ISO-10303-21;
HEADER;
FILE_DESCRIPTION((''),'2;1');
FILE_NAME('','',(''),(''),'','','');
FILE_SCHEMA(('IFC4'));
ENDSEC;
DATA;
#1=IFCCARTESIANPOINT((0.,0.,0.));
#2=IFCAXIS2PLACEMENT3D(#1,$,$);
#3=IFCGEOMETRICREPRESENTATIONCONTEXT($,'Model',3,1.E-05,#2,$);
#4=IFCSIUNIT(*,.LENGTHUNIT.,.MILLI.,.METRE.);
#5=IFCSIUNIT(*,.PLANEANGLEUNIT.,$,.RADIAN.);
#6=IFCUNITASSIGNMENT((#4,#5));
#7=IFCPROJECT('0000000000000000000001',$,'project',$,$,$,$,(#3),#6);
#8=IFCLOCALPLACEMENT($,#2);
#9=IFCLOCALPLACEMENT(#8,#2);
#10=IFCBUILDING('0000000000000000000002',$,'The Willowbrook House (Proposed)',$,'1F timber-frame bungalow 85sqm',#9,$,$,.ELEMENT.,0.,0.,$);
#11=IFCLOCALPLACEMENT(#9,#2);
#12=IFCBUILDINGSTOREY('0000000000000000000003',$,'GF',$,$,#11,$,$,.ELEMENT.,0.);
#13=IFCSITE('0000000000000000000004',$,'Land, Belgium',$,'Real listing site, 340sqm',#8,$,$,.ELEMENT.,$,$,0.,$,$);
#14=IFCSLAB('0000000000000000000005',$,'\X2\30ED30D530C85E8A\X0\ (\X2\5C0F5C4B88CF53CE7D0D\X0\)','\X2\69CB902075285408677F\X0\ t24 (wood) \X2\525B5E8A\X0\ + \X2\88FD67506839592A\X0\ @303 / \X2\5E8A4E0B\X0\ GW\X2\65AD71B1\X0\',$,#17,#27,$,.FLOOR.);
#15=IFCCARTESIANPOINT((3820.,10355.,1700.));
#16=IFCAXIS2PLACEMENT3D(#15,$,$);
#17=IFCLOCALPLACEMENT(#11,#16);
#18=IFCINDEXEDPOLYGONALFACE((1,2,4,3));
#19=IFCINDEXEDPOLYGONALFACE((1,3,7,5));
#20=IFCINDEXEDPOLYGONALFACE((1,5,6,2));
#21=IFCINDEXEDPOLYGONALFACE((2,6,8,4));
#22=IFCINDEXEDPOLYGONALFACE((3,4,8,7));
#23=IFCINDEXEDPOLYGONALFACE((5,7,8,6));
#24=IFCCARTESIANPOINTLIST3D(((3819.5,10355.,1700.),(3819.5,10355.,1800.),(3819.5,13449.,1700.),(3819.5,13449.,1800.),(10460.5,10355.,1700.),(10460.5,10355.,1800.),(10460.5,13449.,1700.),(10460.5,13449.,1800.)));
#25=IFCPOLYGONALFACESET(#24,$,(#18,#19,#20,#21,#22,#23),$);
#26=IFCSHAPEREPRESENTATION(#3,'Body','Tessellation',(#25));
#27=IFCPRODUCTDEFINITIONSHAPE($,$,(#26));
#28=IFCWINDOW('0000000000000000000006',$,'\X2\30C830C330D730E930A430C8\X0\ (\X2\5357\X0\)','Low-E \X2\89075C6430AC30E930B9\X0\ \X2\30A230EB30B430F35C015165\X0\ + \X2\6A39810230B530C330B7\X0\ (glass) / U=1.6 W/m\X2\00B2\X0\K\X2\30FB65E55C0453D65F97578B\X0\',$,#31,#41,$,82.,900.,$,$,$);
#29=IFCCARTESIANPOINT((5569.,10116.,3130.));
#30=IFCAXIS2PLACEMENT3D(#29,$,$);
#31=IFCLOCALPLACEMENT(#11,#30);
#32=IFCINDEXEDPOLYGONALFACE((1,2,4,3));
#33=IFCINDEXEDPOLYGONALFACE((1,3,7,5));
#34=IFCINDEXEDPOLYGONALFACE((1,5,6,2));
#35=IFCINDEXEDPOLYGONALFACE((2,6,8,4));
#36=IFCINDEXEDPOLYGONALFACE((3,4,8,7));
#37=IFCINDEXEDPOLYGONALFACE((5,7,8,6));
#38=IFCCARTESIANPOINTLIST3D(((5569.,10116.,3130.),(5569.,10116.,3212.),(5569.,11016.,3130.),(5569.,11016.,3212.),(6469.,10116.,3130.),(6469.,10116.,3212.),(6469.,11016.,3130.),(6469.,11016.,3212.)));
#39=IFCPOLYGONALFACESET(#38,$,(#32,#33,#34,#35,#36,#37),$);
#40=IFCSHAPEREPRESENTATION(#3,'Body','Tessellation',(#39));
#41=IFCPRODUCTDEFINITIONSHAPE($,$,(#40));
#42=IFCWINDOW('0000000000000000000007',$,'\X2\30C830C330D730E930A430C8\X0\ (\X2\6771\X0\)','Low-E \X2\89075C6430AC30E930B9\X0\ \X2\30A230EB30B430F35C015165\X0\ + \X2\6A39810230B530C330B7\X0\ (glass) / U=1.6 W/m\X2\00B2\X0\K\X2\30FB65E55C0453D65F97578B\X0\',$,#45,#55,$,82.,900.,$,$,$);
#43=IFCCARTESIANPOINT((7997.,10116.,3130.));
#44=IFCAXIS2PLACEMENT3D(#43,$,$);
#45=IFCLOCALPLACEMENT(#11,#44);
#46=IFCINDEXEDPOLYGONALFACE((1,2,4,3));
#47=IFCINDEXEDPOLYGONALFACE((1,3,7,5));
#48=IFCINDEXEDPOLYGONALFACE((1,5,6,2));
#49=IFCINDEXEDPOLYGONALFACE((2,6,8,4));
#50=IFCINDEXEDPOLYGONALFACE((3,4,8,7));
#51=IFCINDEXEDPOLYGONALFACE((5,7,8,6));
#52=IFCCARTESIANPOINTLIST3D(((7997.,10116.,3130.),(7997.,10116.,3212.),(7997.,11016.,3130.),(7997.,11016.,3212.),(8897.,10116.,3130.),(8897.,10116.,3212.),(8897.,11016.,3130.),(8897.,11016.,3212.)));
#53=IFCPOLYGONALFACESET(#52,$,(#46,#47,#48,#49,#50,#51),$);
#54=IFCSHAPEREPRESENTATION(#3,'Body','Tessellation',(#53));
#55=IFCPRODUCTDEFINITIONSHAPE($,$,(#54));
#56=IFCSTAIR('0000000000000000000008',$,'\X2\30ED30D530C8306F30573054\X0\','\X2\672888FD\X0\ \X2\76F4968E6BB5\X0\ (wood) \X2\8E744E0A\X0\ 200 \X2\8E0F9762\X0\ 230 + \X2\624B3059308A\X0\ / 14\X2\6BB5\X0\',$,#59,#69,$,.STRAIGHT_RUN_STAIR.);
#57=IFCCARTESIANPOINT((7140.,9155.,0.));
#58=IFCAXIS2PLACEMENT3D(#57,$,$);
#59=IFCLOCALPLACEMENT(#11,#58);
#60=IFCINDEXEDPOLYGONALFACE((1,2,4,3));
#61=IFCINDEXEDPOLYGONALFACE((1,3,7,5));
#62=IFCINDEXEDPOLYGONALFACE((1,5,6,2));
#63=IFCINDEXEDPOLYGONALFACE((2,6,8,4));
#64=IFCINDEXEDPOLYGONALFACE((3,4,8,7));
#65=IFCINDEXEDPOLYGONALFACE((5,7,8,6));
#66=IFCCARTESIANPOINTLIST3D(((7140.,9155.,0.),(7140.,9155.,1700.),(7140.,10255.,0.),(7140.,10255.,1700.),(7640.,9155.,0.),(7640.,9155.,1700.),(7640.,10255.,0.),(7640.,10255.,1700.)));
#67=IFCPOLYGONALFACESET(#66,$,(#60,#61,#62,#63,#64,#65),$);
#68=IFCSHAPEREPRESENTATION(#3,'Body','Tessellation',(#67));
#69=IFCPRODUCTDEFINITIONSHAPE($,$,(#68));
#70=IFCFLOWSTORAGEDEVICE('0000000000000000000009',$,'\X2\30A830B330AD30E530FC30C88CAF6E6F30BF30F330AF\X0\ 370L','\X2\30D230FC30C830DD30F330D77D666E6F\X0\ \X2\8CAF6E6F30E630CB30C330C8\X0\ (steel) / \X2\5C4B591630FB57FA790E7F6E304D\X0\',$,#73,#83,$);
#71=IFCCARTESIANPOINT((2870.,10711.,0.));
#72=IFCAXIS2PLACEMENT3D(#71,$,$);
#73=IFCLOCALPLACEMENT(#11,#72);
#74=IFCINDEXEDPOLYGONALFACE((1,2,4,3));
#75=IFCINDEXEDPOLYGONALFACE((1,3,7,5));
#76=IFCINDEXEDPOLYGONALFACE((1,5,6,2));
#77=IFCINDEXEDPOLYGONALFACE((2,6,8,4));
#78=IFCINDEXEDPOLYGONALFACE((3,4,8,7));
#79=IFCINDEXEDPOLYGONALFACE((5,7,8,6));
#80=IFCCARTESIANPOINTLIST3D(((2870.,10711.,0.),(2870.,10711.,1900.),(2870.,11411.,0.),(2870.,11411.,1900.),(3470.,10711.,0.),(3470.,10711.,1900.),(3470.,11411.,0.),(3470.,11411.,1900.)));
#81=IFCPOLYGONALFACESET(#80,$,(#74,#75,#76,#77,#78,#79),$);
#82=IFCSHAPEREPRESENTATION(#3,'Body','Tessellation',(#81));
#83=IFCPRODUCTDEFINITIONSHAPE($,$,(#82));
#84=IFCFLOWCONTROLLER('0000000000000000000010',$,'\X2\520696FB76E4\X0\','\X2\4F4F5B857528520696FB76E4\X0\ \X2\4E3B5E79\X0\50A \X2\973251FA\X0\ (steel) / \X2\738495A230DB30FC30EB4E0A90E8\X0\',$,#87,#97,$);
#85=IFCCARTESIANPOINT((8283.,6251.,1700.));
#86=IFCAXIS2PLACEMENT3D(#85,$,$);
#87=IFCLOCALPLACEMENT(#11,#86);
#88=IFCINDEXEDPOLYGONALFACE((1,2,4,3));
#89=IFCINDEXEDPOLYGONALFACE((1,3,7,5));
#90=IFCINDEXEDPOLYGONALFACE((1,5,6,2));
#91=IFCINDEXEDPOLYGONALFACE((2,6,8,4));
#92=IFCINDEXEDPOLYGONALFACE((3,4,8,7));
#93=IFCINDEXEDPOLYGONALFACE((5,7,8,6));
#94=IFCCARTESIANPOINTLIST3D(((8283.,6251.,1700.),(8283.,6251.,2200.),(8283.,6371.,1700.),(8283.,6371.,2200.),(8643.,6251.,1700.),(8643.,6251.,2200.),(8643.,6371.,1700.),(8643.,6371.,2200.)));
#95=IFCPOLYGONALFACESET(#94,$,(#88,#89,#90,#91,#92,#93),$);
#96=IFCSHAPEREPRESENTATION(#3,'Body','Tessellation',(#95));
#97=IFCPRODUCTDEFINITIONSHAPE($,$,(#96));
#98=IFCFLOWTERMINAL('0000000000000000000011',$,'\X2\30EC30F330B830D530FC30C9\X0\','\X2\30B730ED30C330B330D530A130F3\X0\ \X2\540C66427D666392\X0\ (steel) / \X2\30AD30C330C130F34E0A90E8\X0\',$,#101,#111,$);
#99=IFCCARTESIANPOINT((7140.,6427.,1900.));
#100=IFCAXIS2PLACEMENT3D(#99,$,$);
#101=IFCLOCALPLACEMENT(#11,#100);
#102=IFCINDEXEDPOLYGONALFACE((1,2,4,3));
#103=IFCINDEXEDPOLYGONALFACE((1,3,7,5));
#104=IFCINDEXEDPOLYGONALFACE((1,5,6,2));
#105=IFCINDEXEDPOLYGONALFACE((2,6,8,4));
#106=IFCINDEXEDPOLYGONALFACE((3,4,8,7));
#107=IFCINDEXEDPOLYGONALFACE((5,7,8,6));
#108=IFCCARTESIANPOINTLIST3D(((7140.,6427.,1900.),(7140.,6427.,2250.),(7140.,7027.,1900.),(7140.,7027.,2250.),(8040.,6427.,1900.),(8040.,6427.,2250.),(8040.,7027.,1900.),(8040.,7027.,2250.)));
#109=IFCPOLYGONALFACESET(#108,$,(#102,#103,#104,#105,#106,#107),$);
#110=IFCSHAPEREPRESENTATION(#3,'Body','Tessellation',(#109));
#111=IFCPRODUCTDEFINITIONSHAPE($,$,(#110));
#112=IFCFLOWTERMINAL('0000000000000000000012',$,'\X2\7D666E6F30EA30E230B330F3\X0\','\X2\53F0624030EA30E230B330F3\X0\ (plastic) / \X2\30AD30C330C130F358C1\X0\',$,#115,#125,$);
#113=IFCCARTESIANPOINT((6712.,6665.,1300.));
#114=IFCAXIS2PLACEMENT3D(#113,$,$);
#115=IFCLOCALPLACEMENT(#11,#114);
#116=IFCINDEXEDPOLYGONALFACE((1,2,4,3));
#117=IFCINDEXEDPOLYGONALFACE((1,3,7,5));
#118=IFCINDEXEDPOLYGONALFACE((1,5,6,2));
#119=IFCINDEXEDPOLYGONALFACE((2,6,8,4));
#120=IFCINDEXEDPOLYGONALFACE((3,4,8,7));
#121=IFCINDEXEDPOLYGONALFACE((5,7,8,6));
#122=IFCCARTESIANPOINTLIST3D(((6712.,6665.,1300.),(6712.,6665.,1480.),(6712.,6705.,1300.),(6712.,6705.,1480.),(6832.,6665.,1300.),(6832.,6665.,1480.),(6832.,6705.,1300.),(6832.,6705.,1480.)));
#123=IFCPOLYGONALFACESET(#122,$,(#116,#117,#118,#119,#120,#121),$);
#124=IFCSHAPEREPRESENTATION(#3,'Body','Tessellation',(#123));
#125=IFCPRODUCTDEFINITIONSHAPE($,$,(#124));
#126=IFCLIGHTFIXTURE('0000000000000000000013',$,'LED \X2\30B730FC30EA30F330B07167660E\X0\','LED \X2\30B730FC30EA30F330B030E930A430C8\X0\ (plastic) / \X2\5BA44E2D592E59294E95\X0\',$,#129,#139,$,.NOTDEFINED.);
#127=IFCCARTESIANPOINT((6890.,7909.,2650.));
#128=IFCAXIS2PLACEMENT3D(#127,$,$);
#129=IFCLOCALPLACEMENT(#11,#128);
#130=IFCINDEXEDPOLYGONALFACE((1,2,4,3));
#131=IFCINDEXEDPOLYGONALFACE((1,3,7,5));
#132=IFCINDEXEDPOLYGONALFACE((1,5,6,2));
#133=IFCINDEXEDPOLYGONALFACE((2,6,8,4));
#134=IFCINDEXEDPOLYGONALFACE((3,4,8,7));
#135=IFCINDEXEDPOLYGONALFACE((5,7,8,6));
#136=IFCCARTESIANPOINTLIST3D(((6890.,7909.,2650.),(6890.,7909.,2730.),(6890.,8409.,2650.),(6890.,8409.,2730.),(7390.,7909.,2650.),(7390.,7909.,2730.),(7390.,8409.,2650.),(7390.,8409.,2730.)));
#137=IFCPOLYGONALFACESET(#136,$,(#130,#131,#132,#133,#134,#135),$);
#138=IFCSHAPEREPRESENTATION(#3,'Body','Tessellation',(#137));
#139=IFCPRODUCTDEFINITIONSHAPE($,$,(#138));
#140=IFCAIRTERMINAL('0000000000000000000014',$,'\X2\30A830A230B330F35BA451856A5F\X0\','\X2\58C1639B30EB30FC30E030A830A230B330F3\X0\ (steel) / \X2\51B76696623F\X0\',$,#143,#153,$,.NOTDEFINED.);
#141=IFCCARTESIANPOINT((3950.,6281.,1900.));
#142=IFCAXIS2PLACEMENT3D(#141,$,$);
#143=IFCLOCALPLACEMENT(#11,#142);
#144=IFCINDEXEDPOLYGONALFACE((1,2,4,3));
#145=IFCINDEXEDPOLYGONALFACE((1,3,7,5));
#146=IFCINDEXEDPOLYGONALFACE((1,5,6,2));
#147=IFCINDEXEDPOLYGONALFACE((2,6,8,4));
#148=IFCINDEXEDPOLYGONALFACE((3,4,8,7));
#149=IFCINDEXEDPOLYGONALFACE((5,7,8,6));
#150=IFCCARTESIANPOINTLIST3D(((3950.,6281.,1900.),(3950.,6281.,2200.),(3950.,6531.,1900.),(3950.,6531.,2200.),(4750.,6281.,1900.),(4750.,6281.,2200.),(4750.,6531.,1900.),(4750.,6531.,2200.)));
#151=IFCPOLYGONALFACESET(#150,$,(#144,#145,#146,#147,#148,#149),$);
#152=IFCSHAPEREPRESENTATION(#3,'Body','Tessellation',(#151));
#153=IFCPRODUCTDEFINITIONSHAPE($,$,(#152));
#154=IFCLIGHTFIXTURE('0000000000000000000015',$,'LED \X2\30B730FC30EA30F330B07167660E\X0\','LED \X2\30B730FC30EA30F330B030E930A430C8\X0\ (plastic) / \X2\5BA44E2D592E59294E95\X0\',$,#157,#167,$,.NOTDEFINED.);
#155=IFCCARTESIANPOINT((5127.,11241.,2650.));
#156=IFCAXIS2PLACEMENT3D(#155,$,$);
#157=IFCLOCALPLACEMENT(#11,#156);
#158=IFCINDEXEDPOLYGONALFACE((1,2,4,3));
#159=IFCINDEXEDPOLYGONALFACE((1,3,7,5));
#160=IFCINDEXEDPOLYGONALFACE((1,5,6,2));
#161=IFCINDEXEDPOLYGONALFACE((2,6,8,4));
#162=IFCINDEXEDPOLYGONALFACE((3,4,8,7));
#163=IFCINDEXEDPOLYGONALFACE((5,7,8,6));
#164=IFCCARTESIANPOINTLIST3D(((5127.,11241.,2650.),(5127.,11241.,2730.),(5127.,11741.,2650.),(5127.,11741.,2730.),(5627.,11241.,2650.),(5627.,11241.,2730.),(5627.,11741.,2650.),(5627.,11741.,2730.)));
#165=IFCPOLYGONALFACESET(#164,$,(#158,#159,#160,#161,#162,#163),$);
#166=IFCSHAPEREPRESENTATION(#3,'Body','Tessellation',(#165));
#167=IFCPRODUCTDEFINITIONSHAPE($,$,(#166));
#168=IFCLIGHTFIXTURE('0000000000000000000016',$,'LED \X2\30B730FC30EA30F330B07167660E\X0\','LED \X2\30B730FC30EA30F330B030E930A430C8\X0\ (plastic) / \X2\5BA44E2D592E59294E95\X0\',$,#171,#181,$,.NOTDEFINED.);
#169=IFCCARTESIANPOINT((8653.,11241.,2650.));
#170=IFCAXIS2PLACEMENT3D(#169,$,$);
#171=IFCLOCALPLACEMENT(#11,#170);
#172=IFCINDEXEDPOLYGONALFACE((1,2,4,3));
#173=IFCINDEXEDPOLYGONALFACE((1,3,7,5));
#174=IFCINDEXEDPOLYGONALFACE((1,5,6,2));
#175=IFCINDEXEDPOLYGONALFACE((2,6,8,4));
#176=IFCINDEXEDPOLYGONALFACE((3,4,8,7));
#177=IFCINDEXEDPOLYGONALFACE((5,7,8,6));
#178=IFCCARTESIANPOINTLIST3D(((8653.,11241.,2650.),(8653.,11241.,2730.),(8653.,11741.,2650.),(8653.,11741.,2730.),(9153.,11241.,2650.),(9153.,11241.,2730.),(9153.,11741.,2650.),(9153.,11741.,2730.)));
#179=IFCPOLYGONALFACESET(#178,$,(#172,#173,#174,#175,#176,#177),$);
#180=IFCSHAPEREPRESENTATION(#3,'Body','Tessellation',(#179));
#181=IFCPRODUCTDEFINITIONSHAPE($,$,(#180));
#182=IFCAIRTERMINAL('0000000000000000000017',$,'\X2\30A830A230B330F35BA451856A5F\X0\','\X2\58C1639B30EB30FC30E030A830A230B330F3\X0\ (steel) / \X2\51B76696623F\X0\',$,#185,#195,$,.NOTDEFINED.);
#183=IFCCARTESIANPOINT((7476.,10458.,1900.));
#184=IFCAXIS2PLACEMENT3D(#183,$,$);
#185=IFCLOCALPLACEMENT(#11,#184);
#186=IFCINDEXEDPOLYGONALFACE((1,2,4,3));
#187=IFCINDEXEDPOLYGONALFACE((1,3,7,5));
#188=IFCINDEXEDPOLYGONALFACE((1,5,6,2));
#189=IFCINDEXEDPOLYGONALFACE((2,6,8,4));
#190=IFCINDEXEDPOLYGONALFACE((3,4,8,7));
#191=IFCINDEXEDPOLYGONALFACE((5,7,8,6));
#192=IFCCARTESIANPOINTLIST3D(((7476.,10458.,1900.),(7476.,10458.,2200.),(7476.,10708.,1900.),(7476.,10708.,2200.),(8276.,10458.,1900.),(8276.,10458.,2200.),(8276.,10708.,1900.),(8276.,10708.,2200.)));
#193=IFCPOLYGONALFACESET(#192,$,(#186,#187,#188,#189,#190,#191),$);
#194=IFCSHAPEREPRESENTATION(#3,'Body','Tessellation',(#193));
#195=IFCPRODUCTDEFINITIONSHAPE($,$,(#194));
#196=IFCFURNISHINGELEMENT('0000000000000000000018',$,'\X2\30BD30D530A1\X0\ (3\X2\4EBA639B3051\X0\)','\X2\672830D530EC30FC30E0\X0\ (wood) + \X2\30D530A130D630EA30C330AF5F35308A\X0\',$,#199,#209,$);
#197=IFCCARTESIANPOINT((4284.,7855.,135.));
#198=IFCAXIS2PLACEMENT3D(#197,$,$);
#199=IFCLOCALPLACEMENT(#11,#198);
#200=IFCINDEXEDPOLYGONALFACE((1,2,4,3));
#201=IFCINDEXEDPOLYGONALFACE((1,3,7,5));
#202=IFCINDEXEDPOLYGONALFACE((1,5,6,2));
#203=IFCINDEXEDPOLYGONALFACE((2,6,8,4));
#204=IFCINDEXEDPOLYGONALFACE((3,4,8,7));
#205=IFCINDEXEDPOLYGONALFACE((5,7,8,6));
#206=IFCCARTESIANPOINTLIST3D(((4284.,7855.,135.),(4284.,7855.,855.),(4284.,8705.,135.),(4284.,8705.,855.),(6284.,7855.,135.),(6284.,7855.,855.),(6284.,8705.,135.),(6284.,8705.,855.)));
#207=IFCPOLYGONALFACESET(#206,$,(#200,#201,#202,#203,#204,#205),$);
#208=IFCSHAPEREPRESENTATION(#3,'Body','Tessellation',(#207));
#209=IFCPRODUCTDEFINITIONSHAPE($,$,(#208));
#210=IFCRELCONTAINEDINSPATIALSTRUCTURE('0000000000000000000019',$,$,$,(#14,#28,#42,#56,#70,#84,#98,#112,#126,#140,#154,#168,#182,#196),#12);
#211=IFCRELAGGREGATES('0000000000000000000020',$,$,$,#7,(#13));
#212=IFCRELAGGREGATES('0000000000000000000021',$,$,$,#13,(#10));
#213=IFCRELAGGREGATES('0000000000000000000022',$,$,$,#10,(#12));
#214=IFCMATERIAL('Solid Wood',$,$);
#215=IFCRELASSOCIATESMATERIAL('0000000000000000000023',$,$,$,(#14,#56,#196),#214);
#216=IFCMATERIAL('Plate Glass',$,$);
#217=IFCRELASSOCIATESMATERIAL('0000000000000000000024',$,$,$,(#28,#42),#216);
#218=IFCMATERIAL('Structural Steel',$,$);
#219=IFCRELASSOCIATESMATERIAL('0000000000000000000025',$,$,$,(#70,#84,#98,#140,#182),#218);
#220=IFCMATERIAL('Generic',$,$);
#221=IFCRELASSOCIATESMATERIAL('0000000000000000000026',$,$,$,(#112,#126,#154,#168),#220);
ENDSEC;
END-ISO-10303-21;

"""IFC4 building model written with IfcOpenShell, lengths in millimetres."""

from ifc_helpers import new_model, si_unit, frame, frame_2d, origin, place, context, project, spatial, rectangle, extrude, material, element, save


model = new_model("IFC4")

# Units and contexts
model_context = context("Model", 3, precision=1e-05, world=origin())
ifc_project = project(units=[si_unit("LENGTHUNIT", "METRE", prefix="MILLI"), si_unit("PLANEANGLEUNIT", "RADIAN")], contexts=[model_context])

# Site, building, storey
site_placement = place(None, origin())
site = spatial("IfcSite", under=ifc_project, at=site_placement, Name="Land, Belgium", ObjectType="Real listing site, 340sqm", CompositionType="ELEMENT", RefElevation=0.0)
building_placement = place(site_placement, origin())
building = spatial("IfcBuilding", under=site, at=building_placement, Name="The Willowbrook House (Proposed)", ObjectType="1F timber-frame bungalow 85sqm", CompositionType="ELEMENT", ElevationOfRefHeight=0.0, ElevationOfTerrain=0.0)
storey_placement = place(building_placement, origin())
storey = spatial("IfcBuildingStorey", under=building, at=storey_placement, Name="GF", CompositionType="ELEMENT", Elevation=0.0)

# Shared definitions
ifc_material_1 = material(Name="Solid Wood")

# Slab
slab_placement = place(storey_placement, frame((3820.0, 10355.0, 1700.0)))
element("IfcSlab", 1, at=slab_placement, inside=storey, material=ifc_material_1, Name="ロフト床 (小屋裏収納)", Description="構造用合板 t24 (wood) 剛床 + 製材根太 @303 / 床下 GW断熱", PredefinedType="FLOOR", context=model_context, shape_type="SweptSolid", body=[
    extrude(rectangle(XDim=6641.0, YDim=3094.0, at=frame_2d((3320.0, 1547.0))), frame((3820.0, 10355.0, 1700.0)), (0.0, 0.0, 1.0), 100.0),
])

# Windows
ifc_material_2 = material(Name="Plate Glass")
window_1_placement = place(storey_placement, frame((5569.0, 10116.0, 3130.0)))
element("IfcWindow", 2, at=window_1_placement, inside=storey, material=ifc_material_2, Name="トップライト (南)", Description="Low-E 複層ガラス アルゴン封入 + 樹脂サッシ (glass) / U=1.6 W/m²K・日射取得型", OverallHeight=82.0, OverallWidth=900.0, context=model_context, shape_type="SweptSolid", body=[
    extrude(rectangle(XDim=900.0, YDim=900.0, at=frame_2d((450.0, 450.0))), frame((5569.0, 10116.0, 3130.0)), (0.0, 0.0, 1.0), 82.0),
])
window_2_placement = place(storey_placement, frame((7997.0, 10116.0, 3130.0)))
element("IfcWindow", 3, at=window_2_placement, inside=storey, material=ifc_material_2, Name="トップライト (東)", Description="Low-E 複層ガラス アルゴン封入 + 樹脂サッシ (glass) / U=1.6 W/m²K・日射取得型", OverallHeight=82.0, OverallWidth=900.0, context=model_context, shape_type="SweptSolid", body=[
    extrude(rectangle(XDim=900.0, YDim=900.0, at=frame_2d((450.0, 450.0))), frame((7997.0, 10116.0, 3130.0)), (0.0, 0.0, 1.0), 82.0),
])

# Stair
stair_placement = place(storey_placement, frame((7140.0, 9155.0, 0.0)))
element("IfcStair", 4, at=stair_placement, inside=storey, material=ifc_material_1, Name="ロフトはしご", Description="木製 直階段 (wood) 蹴上 200 踏面 230 + 手すり / 14段", PredefinedType="STRAIGHT_RUN_STAIR", context=model_context, shape_type="SweptSolid", body=[
    extrude(rectangle(XDim=500.0, YDim=1100.0, at=frame_2d((250.0, 550.0))), frame((7140.0, 9155.0, 0.0)), (0.0, 0.0, 1.0), 1700.0),
])

# Flow storage device
ifc_material_3 = material(Name="Structural Steel")
flow_storage_device_placement = place(storey_placement, frame((2870.0, 10711.0, 0.0)))
element("IfcFlowStorageDevice", 5, at=flow_storage_device_placement, inside=storey, material=ifc_material_3, Name="エコキュート貯湯タンク 370L", Description="ヒートポンプ給湯 貯湯ユニット (steel) / 屋外・基礎置き", context=model_context, shape_type="SweptSolid", body=[
    extrude(rectangle(XDim=600.0, YDim=700.0, at=frame_2d((300.0, 350.0))), frame((2870.0, 10711.0, 0.0)), (0.0, 0.0, 1.0), 1900.0),
])

# Flow controller
flow_controller_placement = place(storey_placement, frame((8283.0, 6251.0, 1700.0)))
element("IfcFlowController", 6, at=flow_controller_placement, inside=storey, material=ifc_material_3, Name="分電盤", Description="住宅用分電盤 主幹50A 露出 (steel) / 玄関ホール上部", context=model_context, shape_type="SweptSolid", body=[
    extrude(rectangle(XDim=360.0, YDim=120.0, at=frame_2d((180.0, 60.0))), frame((8283.0, 6251.0, 1700.0)), (0.0, 0.0, 1.0), 500.0),
])

# Flow terminals
flow_terminal_1_placement = place(storey_placement, frame((7140.0, 6427.0, 1900.0)))
element("IfcFlowTerminal", 7, at=flow_terminal_1_placement, inside=storey, material=ifc_material_3, Name="レンジフード", Description="シロッコファン 同時給排 (steel) / キッチン上部", context=model_context, shape_type="SweptSolid", body=[
    extrude(rectangle(XDim=900.0, YDim=600.0, at=frame_2d((450.0, 300.0))), frame((7140.0, 6427.0, 1900.0)), (0.0, 0.0, 1.0), 350.0),
])
ifc_material_4 = material(Name="Generic")
flow_terminal_2_placement = place(storey_placement, frame((6712.0, 6665.0, 1300.0)))
element("IfcFlowTerminal", 8, at=flow_terminal_2_placement, inside=storey, material=ifc_material_4, Name="給湯リモコン", Description="台所リモコン (plastic) / キッチン壁", context=model_context, shape_type="SweptSolid", body=[
    extrude(rectangle(XDim=120.0, YDim=40.0, at=frame_2d((60.0, 20.0))), frame((6712.0, 6665.0, 1300.0)), (0.0, 0.0, 1.0), 180.0),
])

# Light fixture
light_fixture_1_placement = place(storey_placement, frame((6890.0, 7909.0, 2650.0)))
element("IfcLightFixture", 9, at=light_fixture_1_placement, inside=storey, material=ifc_material_4, Name="LED シーリング照明", Description="LED シーリングライト (plastic) / 室中央天井", PredefinedType="NOTDEFINED", context=model_context, shape_type="SweptSolid", body=[
    extrude(rectangle(XDim=500.0, YDim=500.0, at=frame_2d((250.0, 250.0))), frame((6890.0, 7909.0, 2650.0)), (0.0, 0.0, 1.0), 80.0),
])

# Air terminal
air_terminal_1_placement = place(storey_placement, frame((3950.0, 6281.0, 1900.0)))
element("IfcAirTerminal", 10, at=air_terminal_1_placement, inside=storey, material=ifc_material_3, Name="エアコン室内機", Description="壁掛ルームエアコン (steel) / 冷暖房", PredefinedType="NOTDEFINED", context=model_context, shape_type="SweptSolid", body=[
    extrude(rectangle(XDim=800.0, YDim=250.0, at=frame_2d((400.0, 125.0))), frame((3950.0, 6281.0, 1900.0)), (0.0, 0.0, 1.0), 300.0),
])

# Light fixtures
light_fixture_2_placement = place(storey_placement, frame((5127.0, 11241.0, 2650.0)))
element("IfcLightFixture", 11, at=light_fixture_2_placement, inside=storey, material=ifc_material_4, Name="LED シーリング照明", Description="LED シーリングライト (plastic) / 室中央天井", PredefinedType="NOTDEFINED", context=model_context, shape_type="SweptSolid", body=[
    extrude(rectangle(XDim=500.0, YDim=500.0, at=frame_2d((250.0, 250.0))), frame((5127.0, 11241.0, 2650.0)), (0.0, 0.0, 1.0), 80.0),
])
light_fixture_3_placement = place(storey_placement, frame((8653.0, 11241.0, 2650.0)))
element("IfcLightFixture", 12, at=light_fixture_3_placement, inside=storey, material=ifc_material_4, Name="LED シーリング照明", Description="LED シーリングライト (plastic) / 室中央天井", PredefinedType="NOTDEFINED", context=model_context, shape_type="SweptSolid", body=[
    extrude(rectangle(XDim=500.0, YDim=500.0, at=frame_2d((250.0, 250.0))), frame((8653.0, 11241.0, 2650.0)), (0.0, 0.0, 1.0), 80.0),
])

# Air terminal
air_terminal_2_placement = place(storey_placement, frame((7476.0, 10458.0, 1900.0)))
element("IfcAirTerminal", 13, at=air_terminal_2_placement, inside=storey, material=ifc_material_3, Name="エアコン室内機", Description="壁掛ルームエアコン (steel) / 冷暖房", PredefinedType="NOTDEFINED", context=model_context, shape_type="SweptSolid", body=[
    extrude(rectangle(XDim=800.0, YDim=250.0, at=frame_2d((400.0, 125.0))), frame((7476.0, 10458.0, 1900.0)), (0.0, 0.0, 1.0), 300.0),
])

# Furnishing element
furnishing_1_placement = place(storey_placement, frame((4284.0, 7855.0, 135.0)))
element("IfcFurnishingElement", 14, at=furnishing_1_placement, inside=storey, material=ifc_material_1, Name="ソファ (3人掛け)", Description="木フレーム (wood) + ファブリック張り", context=model_context, shape_type="SweptSolid", body=[
    extrude(rectangle(XDim=2000.0, YDim=850.0, at=frame_2d((1000.0, 425.0))), frame((4284.0, 7855.0, 135.0)), (0.0, 0.0, 1.0), 720.0),
])

save(model, "model.ifc")
